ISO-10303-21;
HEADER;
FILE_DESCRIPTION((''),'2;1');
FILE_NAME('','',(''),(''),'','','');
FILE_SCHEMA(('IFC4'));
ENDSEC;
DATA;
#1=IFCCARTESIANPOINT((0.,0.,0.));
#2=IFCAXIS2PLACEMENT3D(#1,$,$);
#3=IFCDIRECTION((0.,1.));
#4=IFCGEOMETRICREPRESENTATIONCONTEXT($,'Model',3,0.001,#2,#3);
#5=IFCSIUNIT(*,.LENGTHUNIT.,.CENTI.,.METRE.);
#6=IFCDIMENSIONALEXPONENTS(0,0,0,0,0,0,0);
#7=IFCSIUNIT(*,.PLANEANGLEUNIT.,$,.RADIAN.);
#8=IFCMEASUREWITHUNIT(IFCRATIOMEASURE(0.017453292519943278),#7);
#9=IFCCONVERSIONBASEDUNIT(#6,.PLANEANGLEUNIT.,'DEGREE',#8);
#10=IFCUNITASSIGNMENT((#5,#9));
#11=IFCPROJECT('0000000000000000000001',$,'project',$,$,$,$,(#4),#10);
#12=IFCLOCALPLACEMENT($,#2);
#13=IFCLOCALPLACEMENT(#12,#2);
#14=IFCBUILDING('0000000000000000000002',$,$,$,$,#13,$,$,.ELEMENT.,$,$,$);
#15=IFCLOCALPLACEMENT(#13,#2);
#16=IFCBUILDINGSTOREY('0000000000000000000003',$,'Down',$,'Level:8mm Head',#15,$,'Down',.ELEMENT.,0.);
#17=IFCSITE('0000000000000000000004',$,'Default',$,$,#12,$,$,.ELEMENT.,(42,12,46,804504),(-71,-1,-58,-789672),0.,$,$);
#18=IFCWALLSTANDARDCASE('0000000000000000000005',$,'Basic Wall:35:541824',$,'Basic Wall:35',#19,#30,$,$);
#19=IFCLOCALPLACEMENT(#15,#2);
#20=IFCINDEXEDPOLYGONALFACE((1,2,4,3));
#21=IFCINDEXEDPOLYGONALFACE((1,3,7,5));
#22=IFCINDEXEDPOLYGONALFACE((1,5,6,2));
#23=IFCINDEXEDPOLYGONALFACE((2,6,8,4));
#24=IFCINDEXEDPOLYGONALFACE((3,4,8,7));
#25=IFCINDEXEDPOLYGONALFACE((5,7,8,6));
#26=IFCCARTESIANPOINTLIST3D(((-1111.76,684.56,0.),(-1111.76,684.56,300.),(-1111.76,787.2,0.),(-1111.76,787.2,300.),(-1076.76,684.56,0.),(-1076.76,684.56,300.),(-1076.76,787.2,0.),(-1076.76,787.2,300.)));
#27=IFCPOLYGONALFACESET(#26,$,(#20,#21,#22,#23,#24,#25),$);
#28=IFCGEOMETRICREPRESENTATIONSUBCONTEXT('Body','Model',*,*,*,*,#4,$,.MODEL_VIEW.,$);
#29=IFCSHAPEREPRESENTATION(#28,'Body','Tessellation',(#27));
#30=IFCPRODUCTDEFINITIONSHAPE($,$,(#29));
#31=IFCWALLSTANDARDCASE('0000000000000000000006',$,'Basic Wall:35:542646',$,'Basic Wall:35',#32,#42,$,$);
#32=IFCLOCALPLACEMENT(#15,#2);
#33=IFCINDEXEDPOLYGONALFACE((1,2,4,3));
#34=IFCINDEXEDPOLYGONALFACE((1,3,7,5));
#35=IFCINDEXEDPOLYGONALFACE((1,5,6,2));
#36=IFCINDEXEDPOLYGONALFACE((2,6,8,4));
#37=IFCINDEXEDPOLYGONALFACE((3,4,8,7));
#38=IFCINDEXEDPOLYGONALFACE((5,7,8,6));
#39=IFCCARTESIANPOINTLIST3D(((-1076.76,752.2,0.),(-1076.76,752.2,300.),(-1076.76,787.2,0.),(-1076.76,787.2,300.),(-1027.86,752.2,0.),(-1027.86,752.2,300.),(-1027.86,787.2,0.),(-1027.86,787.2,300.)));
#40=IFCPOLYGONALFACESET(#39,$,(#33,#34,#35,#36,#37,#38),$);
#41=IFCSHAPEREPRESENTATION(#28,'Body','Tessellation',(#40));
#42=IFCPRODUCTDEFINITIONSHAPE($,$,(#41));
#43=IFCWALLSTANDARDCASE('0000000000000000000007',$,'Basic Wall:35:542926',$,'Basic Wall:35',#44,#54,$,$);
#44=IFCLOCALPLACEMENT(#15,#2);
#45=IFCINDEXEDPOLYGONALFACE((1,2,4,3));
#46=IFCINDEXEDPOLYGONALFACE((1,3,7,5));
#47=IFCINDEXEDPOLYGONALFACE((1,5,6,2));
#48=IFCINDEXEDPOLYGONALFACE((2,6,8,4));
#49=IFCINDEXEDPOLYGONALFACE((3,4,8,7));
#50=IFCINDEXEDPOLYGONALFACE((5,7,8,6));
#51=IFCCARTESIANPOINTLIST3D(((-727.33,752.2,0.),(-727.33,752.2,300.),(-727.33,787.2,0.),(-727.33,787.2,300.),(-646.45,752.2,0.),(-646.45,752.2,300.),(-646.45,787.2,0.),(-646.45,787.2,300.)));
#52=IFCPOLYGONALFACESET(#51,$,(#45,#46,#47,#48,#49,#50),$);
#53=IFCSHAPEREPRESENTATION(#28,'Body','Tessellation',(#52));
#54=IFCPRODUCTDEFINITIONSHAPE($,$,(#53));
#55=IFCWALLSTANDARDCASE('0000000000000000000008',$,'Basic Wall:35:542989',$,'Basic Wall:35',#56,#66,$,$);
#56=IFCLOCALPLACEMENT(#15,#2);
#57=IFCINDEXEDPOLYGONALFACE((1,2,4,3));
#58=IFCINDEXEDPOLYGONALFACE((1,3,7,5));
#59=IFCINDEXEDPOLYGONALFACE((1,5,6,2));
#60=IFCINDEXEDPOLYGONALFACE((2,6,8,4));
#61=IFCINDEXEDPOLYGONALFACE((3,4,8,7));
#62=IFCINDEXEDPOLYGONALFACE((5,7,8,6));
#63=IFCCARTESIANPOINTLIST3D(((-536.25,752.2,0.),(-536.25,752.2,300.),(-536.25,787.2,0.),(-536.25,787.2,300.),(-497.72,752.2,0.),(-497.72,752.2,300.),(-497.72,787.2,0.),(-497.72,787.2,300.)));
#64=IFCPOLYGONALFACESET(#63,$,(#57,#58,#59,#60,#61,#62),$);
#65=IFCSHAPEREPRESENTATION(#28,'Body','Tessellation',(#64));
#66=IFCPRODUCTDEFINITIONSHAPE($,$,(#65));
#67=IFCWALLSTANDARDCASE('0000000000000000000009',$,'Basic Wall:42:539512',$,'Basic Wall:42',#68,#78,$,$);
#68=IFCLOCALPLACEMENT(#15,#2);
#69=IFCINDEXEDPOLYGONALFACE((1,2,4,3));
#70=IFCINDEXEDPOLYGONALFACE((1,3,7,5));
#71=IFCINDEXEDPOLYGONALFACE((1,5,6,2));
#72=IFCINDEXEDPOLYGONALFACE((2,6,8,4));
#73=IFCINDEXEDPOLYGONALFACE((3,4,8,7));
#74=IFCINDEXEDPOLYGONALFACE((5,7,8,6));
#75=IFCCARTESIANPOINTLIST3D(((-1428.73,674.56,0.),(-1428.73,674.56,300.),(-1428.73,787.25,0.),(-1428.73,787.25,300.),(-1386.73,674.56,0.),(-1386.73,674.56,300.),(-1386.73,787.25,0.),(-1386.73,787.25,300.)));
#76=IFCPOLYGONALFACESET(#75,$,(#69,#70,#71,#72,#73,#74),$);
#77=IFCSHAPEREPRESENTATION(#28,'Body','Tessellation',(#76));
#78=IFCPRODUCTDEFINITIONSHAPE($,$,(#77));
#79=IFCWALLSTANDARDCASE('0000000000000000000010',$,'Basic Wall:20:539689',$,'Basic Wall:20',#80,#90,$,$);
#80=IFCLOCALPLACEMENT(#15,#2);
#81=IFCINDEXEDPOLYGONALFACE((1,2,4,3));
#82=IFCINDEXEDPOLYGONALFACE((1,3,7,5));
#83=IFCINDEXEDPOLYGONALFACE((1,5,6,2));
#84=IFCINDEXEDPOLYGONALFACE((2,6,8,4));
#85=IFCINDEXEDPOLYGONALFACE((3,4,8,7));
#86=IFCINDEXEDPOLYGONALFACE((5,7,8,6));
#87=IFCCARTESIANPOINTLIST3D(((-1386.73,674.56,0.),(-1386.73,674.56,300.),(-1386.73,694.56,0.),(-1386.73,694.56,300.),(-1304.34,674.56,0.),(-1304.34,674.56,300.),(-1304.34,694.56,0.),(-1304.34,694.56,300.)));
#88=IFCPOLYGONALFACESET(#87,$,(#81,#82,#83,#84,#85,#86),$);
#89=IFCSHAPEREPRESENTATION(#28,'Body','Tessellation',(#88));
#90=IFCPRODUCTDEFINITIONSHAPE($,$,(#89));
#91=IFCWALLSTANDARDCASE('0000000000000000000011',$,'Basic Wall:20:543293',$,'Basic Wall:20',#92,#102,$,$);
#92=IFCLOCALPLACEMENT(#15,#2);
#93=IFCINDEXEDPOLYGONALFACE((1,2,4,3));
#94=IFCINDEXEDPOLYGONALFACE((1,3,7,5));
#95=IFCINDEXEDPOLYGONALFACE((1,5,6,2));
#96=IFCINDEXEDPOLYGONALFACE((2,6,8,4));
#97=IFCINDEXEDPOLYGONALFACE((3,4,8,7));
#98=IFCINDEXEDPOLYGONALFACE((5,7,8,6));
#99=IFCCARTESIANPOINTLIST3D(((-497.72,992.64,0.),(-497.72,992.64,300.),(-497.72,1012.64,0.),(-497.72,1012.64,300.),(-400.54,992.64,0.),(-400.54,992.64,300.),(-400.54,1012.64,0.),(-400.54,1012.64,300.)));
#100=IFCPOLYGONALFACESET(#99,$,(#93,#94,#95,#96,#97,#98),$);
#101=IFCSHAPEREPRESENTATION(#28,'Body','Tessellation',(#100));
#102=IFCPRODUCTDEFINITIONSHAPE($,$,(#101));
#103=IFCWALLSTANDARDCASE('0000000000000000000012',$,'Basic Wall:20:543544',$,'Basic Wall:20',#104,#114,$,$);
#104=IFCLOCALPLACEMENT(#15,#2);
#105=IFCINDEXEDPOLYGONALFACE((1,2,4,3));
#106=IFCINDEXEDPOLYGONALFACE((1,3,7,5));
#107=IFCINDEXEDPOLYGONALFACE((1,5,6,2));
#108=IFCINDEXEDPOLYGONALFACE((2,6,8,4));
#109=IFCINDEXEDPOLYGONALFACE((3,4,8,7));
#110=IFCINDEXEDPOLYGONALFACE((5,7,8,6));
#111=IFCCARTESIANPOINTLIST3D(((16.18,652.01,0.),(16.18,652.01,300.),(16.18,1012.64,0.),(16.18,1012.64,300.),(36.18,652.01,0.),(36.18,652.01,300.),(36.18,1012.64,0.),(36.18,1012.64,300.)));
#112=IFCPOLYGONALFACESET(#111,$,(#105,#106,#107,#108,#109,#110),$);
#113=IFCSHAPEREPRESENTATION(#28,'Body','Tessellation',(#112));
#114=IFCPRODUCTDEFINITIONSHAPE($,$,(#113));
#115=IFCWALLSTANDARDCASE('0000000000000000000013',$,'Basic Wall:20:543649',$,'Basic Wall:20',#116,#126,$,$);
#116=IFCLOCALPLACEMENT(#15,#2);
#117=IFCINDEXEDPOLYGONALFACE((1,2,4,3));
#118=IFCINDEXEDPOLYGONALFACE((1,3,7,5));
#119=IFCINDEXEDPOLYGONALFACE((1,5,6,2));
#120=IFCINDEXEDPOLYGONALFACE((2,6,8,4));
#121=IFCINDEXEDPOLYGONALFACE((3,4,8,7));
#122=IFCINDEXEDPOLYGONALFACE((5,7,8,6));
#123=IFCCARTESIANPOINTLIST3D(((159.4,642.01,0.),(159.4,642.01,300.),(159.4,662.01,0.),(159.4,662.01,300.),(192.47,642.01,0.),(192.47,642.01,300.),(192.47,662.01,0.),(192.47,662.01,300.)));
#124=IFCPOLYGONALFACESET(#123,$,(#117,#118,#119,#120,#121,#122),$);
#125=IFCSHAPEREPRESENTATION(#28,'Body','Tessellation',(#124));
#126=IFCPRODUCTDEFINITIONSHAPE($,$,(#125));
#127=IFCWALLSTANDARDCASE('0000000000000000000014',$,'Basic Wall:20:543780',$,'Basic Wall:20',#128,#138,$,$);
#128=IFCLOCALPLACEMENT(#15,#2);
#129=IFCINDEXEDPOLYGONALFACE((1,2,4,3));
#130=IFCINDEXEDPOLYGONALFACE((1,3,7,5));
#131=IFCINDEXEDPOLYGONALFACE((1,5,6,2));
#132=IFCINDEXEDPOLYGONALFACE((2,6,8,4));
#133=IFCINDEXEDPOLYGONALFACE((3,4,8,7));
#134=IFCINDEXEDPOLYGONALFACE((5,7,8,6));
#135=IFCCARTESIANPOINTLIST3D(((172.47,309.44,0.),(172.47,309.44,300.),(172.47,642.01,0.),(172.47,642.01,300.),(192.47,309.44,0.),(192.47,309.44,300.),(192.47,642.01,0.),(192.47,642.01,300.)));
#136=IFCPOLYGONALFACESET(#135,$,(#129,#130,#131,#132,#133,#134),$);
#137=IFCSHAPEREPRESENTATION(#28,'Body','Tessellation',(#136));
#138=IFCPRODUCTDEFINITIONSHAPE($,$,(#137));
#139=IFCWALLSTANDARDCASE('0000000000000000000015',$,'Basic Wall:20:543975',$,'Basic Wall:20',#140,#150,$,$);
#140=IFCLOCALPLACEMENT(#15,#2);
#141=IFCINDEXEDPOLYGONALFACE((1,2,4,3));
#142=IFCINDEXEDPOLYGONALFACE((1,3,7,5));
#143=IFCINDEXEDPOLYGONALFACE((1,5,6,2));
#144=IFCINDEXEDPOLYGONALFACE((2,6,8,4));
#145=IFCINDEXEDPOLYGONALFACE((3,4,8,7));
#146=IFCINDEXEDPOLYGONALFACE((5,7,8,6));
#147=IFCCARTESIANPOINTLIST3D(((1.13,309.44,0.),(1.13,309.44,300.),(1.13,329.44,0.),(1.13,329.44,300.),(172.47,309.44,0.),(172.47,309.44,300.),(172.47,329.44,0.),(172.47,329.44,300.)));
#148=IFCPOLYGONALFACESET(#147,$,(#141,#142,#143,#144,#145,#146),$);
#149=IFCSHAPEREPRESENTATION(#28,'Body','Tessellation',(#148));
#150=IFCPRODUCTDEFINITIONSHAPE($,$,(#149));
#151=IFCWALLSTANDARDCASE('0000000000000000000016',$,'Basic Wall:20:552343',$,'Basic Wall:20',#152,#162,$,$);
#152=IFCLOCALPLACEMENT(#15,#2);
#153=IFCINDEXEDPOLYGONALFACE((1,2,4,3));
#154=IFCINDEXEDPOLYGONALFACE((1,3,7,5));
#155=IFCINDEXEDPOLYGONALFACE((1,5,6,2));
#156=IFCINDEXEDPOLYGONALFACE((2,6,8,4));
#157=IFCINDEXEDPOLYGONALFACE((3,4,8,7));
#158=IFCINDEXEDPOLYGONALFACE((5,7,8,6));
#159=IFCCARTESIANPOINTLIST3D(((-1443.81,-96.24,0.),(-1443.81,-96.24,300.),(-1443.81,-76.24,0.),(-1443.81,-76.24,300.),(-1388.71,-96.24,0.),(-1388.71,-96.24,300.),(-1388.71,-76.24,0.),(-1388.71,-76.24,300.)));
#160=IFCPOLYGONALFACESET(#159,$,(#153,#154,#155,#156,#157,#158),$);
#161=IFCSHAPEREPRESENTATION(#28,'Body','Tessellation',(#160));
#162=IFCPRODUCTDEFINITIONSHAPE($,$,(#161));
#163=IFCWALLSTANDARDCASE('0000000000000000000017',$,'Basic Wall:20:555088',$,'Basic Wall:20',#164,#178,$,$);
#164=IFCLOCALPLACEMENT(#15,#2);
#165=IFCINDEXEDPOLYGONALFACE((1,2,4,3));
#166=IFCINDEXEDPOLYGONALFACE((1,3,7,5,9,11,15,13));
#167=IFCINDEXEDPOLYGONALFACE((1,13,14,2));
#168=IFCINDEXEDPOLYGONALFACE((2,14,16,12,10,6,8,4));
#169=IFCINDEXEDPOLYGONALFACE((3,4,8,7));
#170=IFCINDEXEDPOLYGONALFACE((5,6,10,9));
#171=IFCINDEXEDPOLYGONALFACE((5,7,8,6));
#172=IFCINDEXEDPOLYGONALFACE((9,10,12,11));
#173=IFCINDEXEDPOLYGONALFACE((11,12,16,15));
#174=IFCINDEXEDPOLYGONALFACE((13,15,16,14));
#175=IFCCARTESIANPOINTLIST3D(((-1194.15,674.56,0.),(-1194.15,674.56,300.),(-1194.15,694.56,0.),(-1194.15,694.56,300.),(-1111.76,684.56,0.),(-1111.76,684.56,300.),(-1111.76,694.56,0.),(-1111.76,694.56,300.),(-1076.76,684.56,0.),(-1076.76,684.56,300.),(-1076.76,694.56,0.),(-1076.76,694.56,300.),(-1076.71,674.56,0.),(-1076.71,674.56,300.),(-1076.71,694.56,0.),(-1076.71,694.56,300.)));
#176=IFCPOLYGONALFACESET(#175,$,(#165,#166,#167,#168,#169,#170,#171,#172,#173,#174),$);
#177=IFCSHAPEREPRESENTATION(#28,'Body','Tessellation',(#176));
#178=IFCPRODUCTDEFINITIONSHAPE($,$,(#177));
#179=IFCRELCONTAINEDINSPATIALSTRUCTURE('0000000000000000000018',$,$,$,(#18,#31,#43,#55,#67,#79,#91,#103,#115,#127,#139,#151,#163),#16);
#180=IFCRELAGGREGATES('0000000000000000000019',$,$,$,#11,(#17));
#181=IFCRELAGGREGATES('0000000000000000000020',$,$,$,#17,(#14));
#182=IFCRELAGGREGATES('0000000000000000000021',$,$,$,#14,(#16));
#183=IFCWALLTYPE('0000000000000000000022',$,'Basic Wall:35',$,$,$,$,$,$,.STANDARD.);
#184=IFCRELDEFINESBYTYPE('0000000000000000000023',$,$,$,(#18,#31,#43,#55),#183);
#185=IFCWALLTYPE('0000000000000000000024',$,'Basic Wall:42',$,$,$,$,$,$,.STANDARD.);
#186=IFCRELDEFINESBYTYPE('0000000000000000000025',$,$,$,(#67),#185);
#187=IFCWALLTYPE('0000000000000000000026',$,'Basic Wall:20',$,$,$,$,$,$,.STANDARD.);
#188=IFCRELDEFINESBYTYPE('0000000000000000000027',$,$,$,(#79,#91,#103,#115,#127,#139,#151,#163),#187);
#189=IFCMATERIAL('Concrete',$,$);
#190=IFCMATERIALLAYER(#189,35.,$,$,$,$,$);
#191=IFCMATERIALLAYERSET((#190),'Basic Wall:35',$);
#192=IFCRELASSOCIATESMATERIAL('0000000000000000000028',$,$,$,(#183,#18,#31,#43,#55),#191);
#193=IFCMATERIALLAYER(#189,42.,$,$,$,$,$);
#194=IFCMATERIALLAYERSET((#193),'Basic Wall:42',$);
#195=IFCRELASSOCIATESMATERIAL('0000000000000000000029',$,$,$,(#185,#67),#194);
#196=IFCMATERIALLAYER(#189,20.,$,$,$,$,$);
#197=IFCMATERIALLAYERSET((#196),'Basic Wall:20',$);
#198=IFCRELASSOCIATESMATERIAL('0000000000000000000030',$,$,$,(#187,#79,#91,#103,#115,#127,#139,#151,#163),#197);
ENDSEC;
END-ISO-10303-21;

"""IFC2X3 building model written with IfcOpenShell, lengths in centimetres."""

from ifc_helpers import new_model, entity, si_unit, converted_unit, direction, frame, frame_2d, origin, place, context, subcontext, project, spatial, polyline, rectangle, extrude, clip, bounded_halfspace, material, layer, layer_set, layer_usage, type_object, element, save


model = new_model("IFC2X3")

# Units and contexts
model_context = context("Model", 3, precision=0.001, world=origin(), true_north=direction((0.0, 1.0)))
body_context = subcontext(model_context, "Body", "Model", "MODEL_VIEW")
ifc_project = project(units=[si_unit("LENGTHUNIT", "METRE", prefix="CENTI"), converted_unit("PLANEANGLEUNIT", "DEGREE", entity("IfcRatioMeasure", 0.017453292519943278), si_unit("PLANEANGLEUNIT", "RADIAN"), dimensions=[0, 0, 0, 0, 0, 0, 0])], contexts=[model_context])

# Site, building, storey
site_placement = place(None, origin())
site = spatial("IfcSite", under=ifc_project, at=site_placement, Name="Default", CompositionType="ELEMENT", RefLatitude=(42, 12, 46, 804504), RefLongitude=(-71, -1, -58, -789672), RefElevation=0.0)
building_placement = place(site_placement, origin())
building = spatial("IfcBuilding", under=site, at=building_placement, CompositionType="ELEMENT")
storey_placement = place(building_placement, origin())
storey = spatial("IfcBuildingStorey", under=building, at=storey_placement, Name="Down", ObjectType="Level:8mm Head", LongName="Down", CompositionType="ELEMENT", Elevation=0.0)

# Walls
ifc_material = material(Name="Concrete")
ifc_layer_1 = layer(ifc_material, 35.0)
ifc_layer_set_1 = layer_set([ifc_layer_1], Name="Basic Wall:35")
wall_type_1 = type_object("IfcWallType", Name="Basic Wall:35", PredefinedType="STANDARD", material=ifc_layer_set_1)
ifc_layer_usage_1 = layer_usage(ifc_layer_set_1, "AXIS2", "POSITIVE", -17.5)
wall_1_placement = place(storey_placement, frame((-1094.26, 684.56, 0.0), z_axis=(0.0, 0.0, 1.0), x_axis=(0.0, 1.0, 0.0)))
element("IfcWallStandardCase", 1, at=wall_1_placement, inside=storey, type_object=wall_type_1, material=ifc_layer_usage_1, Name="Basic Wall:35:541824", ObjectType="Basic Wall:35", context=body_context, shape_type="SweptSolid", body=[
    extrude(rectangle(XDim=102.65, YDim=35.0, at=frame_2d((51.32, 0.0), x_axis=(-1.0, 0.0))), origin(), (0.0, 0.0, 1.0), 300.0),
])
ifc_layer_usage_2 = layer_usage(ifc_layer_set_1, "AXIS2", "POSITIVE", -17.5)
wall_2_placement = place(storey_placement, frame((-1027.86, 769.7, 0.0), z_axis=(0.0, 0.0, 1.0), x_axis=(-1.0, 0.0, 0.0)))
element("IfcWallStandardCase", 2, at=wall_2_placement, inside=storey, type_object=wall_type_1, material=ifc_layer_usage_2, Name="Basic Wall:35:542646", ObjectType="Basic Wall:35", context=body_context, shape_type="SweptSolid", body=[
    extrude(rectangle(XDim=48.9, YDim=35.0, at=frame_2d((24.45, 0.0), x_axis=(-1.0, 0.0))), origin(), (0.0, 0.0, 1.0), 300.0),
])
ifc_layer_usage_3 = layer_usage(ifc_layer_set_1, "AXIS2", "POSITIVE", -17.5)
wall_3_placement = place(storey_placement, frame((-727.33, 769.7, 0.0)))
element("IfcWallStandardCase", 3, at=wall_3_placement, inside=storey, type_object=wall_type_1, material=ifc_layer_usage_3, Name="Basic Wall:35:542926", ObjectType="Basic Wall:35", context=body_context, shape_type="SweptSolid", body=[
    extrude(rectangle(XDim=80.88, YDim=35.0, at=frame_2d((40.44, 0.0), x_axis=(-1.0, 0.0))), origin(), (0.0, 0.0, 1.0), 300.0),
])
ifc_layer_usage_4 = layer_usage(ifc_layer_set_1, "AXIS2", "POSITIVE", -17.5)
wall_4_placement = place(storey_placement, frame((-536.25, 769.7, 0.0)))
element("IfcWallStandardCase", 4, at=wall_4_placement, inside=storey, type_object=wall_type_1, material=ifc_layer_usage_4, Name="Basic Wall:35:542989", ObjectType="Basic Wall:35", context=body_context, shape_type="SweptSolid", body=[
    extrude(rectangle(XDim=38.54, YDim=35.0, at=frame_2d((19.27, 0.0), x_axis=(-1.0, 0.0))), origin(), (0.0, 0.0, 1.0), 300.0),
])
ifc_layer_2 = layer(ifc_material, 42.0)
ifc_layer_set_2 = layer_set([ifc_layer_2], Name="Basic Wall:42")
ifc_layer_usage_5 = layer_usage(ifc_layer_set_2, "AXIS2", "NEGATIVE", 21.0)
wall_type_2 = type_object("IfcWallType", Name="Basic Wall:42", PredefinedType="STANDARD", material=ifc_layer_set_2)
wall_5_placement = place(storey_placement, frame((-1407.73, 787.25, 0.0), z_axis=(0.0, 0.0, 1.0), x_axis=(0.0, -1.0, 0.0)))
element("IfcWallStandardCase", 5, at=wall_5_placement, inside=storey, type_object=wall_type_2, material=ifc_layer_usage_5, Name="Basic Wall:42:539512", ObjectType="Basic Wall:42", context=body_context, shape_type="SweptSolid", body=[
    extrude(rectangle(XDim=112.7, YDim=42.0, at=frame_2d((56.35, 0.0), x_axis=(-1.0, 0.0))), origin(), (0.0, 0.0, 1.0), 300.0),
])
ifc_layer_3 = layer(ifc_material, 20.0)
ifc_layer_set_3 = layer_set([ifc_layer_3], Name="Basic Wall:20")
ifc_layer_usage_6 = layer_usage(ifc_layer_set_3, "AXIS2", "POSITIVE", -10.0)
wall_type_3 = type_object("IfcWallType", Name="Basic Wall:20", PredefinedType="STANDARD", material=ifc_layer_set_3)
wall_6_placement = place(storey_placement, frame((-1386.73, 684.56, 0.0)))
element("IfcWallStandardCase", 6, at=wall_6_placement, inside=storey, type_object=wall_type_3, material=ifc_layer_usage_6, Name="Basic Wall:20:539689", ObjectType="Basic Wall:20", context=body_context, shape_type="SweptSolid", body=[
    extrude(rectangle(XDim=82.39, YDim=20.0, at=frame_2d((41.19, 0.0), x_axis=(-1.0, 0.0))), origin(), (0.0, 0.0, 1.0), 300.0),
])
ifc_layer_usage_7 = layer_usage(ifc_layer_set_3, "AXIS2", "NEGATIVE", 10.0)
wall_7_placement = place(storey_placement, frame((-497.72, 1002.64, 0.0)))
element("IfcWallStandardCase", 7, at=wall_7_placement, inside=storey, type_object=wall_type_3, material=ifc_layer_usage_7, Name="Basic Wall:20:543293", ObjectType="Basic Wall:20", context=body_context, shape_type="SweptSolid", body=[
    extrude(rectangle(XDim=97.18, YDim=20.0, at=frame_2d((48.59, 0.0), x_axis=(-1.0, 0.0))), origin(), (0.0, 0.0, 1.0), 300.0),
])
ifc_layer_usage_8 = layer_usage(ifc_layer_set_3, "AXIS2", "NEGATIVE", 10.0)
wall_8_placement = place(storey_placement, frame((26.18, 1012.64, 0.0), z_axis=(0.0, 0.0, 1.0), x_axis=(0.0, -1.0, 0.0)))
element("IfcWallStandardCase", 8, at=wall_8_placement, inside=storey, type_object=wall_type_3, material=ifc_layer_usage_8, Name="Basic Wall:20:543544", ObjectType="Basic Wall:20", context=body_context, shape_type="SweptSolid", body=[
    extrude(rectangle(XDim=360.64, YDim=20.0, at=frame_2d((180.32, 0.0), x_axis=(-1.0, 0.0))), origin(), (0.0, 0.0, 1.0), 300.0),
])
ifc_layer_usage_9 = layer_usage(ifc_layer_set_3, "AXIS2", "POSITIVE", -10.0)
wall_9_placement = place(storey_placement, frame((159.4, 652.01, 0.0)))
element("IfcWallStandardCase", 9, at=wall_9_placement, inside=storey, type_object=wall_type_3, material=ifc_layer_usage_9, Name="Basic Wall:20:543649", ObjectType="Basic Wall:20", context=body_context, shape_type="SweptSolid", body=[
    extrude(rectangle(XDim=33.07, YDim=20.0, at=frame_2d((16.53, 0.0), x_axis=(-1.0, 0.0))), origin(), (0.0, 0.0, 1.0), 300.0),
])
ifc_layer_usage_10 = layer_usage(ifc_layer_set_3, "AXIS2", "NEGATIVE", 10.0)
wall_10_placement = place(storey_placement, frame((182.47, 642.01, 0.0), z_axis=(0.0, 0.0, 1.0), x_axis=(0.0, -1.0, 0.0)))
element("IfcWallStandardCase", 10, at=wall_10_placement, inside=storey, type_object=wall_type_3, material=ifc_layer_usage_10, Name="Basic Wall:20:543780", ObjectType="Basic Wall:20", context=body_context, shape_type="SweptSolid", body=[
    extrude(rectangle(XDim=332.57, YDim=20.0, at=frame_2d((166.28, 0.0), x_axis=(-1.0, 0.0))), origin(), (0.0, 0.0, 1.0), 300.0),
])
ifc_layer_usage_11 = layer_usage(ifc_layer_set_3, "AXIS2", "NEGATIVE", 10.0)
wall_11_placement = place(storey_placement, frame((172.47, 319.44, 0.0), z_axis=(0.0, 0.0, 1.0), x_axis=(-1.0, 0.0, 0.0)))
element("IfcWallStandardCase", 11, at=wall_11_placement, inside=storey, type_object=wall_type_3, material=ifc_layer_usage_11, Name="Basic Wall:20:543975", ObjectType="Basic Wall:20", context=body_context, shape_type="SweptSolid", body=[
    extrude(rectangle(XDim=171.33, YDim=20.0, at=frame_2d((85.67, 0.0), x_axis=(-1.0, 0.0))), origin(), (0.0, 0.0, 1.0), 300.0),
])
ifc_layer_usage_12 = layer_usage(ifc_layer_set_3, "AXIS2", "NEGATIVE", 10.0)
wall_12_placement = place(storey_placement, frame((-1388.71, -86.24, 0.0), z_axis=(0.0, 0.0, 1.0), x_axis=(-1.0, 0.0, 0.0)))
element("IfcWallStandardCase", 12, at=wall_12_placement, inside=storey, type_object=wall_type_3, material=ifc_layer_usage_12, Name="Basic Wall:20:552343", ObjectType="Basic Wall:20", context=body_context, shape_type="SweptSolid", body=[
    extrude(rectangle(XDim=55.1, YDim=20.0, at=frame_2d((27.55, 0.0), x_axis=(-1.0, 0.0))), origin(), (0.0, 0.0, 1.0), 300.0),
])
ifc_layer_usage_13 = layer_usage(ifc_layer_set_3, "AXIS2", "POSITIVE", -10.0)
wall_13_placement = place(storey_placement, frame((-1194.15, 684.56, 0.0)))
element("IfcWallStandardCase", 13, at=wall_13_placement, inside=storey, type_object=wall_type_3, material=ifc_layer_usage_13, Name="Basic Wall:20:555088", ObjectType="Basic Wall:20", context=body_context, shape_type="Clipping", body=[
    clip(extrude(rectangle(XDim=117.43, YDim=20.0, at=frame_2d((58.72, 0.0), x_axis=(-1.0, 0.0))), origin(), (0.0, 0.0, 1.0), 300.0), bounded_halfspace(frame((117.39, 0.0, 300.0), z_axis=(0.0, -1.0, 0.0), x_axis=(-1.0, 0.0, 0.0)), True, frame((117.39, 0.0, 300.0), z_axis=(0.0, -1.0, 0.0), x_axis=(-1.0, 0.0, 0.0)), polyline([(0.0, 0.0), (35.0, 0.0), (35.0, 300.0), (0.0, 300.0), (0.0, 0.0)]))),
])

save(model, "model.ifc")
